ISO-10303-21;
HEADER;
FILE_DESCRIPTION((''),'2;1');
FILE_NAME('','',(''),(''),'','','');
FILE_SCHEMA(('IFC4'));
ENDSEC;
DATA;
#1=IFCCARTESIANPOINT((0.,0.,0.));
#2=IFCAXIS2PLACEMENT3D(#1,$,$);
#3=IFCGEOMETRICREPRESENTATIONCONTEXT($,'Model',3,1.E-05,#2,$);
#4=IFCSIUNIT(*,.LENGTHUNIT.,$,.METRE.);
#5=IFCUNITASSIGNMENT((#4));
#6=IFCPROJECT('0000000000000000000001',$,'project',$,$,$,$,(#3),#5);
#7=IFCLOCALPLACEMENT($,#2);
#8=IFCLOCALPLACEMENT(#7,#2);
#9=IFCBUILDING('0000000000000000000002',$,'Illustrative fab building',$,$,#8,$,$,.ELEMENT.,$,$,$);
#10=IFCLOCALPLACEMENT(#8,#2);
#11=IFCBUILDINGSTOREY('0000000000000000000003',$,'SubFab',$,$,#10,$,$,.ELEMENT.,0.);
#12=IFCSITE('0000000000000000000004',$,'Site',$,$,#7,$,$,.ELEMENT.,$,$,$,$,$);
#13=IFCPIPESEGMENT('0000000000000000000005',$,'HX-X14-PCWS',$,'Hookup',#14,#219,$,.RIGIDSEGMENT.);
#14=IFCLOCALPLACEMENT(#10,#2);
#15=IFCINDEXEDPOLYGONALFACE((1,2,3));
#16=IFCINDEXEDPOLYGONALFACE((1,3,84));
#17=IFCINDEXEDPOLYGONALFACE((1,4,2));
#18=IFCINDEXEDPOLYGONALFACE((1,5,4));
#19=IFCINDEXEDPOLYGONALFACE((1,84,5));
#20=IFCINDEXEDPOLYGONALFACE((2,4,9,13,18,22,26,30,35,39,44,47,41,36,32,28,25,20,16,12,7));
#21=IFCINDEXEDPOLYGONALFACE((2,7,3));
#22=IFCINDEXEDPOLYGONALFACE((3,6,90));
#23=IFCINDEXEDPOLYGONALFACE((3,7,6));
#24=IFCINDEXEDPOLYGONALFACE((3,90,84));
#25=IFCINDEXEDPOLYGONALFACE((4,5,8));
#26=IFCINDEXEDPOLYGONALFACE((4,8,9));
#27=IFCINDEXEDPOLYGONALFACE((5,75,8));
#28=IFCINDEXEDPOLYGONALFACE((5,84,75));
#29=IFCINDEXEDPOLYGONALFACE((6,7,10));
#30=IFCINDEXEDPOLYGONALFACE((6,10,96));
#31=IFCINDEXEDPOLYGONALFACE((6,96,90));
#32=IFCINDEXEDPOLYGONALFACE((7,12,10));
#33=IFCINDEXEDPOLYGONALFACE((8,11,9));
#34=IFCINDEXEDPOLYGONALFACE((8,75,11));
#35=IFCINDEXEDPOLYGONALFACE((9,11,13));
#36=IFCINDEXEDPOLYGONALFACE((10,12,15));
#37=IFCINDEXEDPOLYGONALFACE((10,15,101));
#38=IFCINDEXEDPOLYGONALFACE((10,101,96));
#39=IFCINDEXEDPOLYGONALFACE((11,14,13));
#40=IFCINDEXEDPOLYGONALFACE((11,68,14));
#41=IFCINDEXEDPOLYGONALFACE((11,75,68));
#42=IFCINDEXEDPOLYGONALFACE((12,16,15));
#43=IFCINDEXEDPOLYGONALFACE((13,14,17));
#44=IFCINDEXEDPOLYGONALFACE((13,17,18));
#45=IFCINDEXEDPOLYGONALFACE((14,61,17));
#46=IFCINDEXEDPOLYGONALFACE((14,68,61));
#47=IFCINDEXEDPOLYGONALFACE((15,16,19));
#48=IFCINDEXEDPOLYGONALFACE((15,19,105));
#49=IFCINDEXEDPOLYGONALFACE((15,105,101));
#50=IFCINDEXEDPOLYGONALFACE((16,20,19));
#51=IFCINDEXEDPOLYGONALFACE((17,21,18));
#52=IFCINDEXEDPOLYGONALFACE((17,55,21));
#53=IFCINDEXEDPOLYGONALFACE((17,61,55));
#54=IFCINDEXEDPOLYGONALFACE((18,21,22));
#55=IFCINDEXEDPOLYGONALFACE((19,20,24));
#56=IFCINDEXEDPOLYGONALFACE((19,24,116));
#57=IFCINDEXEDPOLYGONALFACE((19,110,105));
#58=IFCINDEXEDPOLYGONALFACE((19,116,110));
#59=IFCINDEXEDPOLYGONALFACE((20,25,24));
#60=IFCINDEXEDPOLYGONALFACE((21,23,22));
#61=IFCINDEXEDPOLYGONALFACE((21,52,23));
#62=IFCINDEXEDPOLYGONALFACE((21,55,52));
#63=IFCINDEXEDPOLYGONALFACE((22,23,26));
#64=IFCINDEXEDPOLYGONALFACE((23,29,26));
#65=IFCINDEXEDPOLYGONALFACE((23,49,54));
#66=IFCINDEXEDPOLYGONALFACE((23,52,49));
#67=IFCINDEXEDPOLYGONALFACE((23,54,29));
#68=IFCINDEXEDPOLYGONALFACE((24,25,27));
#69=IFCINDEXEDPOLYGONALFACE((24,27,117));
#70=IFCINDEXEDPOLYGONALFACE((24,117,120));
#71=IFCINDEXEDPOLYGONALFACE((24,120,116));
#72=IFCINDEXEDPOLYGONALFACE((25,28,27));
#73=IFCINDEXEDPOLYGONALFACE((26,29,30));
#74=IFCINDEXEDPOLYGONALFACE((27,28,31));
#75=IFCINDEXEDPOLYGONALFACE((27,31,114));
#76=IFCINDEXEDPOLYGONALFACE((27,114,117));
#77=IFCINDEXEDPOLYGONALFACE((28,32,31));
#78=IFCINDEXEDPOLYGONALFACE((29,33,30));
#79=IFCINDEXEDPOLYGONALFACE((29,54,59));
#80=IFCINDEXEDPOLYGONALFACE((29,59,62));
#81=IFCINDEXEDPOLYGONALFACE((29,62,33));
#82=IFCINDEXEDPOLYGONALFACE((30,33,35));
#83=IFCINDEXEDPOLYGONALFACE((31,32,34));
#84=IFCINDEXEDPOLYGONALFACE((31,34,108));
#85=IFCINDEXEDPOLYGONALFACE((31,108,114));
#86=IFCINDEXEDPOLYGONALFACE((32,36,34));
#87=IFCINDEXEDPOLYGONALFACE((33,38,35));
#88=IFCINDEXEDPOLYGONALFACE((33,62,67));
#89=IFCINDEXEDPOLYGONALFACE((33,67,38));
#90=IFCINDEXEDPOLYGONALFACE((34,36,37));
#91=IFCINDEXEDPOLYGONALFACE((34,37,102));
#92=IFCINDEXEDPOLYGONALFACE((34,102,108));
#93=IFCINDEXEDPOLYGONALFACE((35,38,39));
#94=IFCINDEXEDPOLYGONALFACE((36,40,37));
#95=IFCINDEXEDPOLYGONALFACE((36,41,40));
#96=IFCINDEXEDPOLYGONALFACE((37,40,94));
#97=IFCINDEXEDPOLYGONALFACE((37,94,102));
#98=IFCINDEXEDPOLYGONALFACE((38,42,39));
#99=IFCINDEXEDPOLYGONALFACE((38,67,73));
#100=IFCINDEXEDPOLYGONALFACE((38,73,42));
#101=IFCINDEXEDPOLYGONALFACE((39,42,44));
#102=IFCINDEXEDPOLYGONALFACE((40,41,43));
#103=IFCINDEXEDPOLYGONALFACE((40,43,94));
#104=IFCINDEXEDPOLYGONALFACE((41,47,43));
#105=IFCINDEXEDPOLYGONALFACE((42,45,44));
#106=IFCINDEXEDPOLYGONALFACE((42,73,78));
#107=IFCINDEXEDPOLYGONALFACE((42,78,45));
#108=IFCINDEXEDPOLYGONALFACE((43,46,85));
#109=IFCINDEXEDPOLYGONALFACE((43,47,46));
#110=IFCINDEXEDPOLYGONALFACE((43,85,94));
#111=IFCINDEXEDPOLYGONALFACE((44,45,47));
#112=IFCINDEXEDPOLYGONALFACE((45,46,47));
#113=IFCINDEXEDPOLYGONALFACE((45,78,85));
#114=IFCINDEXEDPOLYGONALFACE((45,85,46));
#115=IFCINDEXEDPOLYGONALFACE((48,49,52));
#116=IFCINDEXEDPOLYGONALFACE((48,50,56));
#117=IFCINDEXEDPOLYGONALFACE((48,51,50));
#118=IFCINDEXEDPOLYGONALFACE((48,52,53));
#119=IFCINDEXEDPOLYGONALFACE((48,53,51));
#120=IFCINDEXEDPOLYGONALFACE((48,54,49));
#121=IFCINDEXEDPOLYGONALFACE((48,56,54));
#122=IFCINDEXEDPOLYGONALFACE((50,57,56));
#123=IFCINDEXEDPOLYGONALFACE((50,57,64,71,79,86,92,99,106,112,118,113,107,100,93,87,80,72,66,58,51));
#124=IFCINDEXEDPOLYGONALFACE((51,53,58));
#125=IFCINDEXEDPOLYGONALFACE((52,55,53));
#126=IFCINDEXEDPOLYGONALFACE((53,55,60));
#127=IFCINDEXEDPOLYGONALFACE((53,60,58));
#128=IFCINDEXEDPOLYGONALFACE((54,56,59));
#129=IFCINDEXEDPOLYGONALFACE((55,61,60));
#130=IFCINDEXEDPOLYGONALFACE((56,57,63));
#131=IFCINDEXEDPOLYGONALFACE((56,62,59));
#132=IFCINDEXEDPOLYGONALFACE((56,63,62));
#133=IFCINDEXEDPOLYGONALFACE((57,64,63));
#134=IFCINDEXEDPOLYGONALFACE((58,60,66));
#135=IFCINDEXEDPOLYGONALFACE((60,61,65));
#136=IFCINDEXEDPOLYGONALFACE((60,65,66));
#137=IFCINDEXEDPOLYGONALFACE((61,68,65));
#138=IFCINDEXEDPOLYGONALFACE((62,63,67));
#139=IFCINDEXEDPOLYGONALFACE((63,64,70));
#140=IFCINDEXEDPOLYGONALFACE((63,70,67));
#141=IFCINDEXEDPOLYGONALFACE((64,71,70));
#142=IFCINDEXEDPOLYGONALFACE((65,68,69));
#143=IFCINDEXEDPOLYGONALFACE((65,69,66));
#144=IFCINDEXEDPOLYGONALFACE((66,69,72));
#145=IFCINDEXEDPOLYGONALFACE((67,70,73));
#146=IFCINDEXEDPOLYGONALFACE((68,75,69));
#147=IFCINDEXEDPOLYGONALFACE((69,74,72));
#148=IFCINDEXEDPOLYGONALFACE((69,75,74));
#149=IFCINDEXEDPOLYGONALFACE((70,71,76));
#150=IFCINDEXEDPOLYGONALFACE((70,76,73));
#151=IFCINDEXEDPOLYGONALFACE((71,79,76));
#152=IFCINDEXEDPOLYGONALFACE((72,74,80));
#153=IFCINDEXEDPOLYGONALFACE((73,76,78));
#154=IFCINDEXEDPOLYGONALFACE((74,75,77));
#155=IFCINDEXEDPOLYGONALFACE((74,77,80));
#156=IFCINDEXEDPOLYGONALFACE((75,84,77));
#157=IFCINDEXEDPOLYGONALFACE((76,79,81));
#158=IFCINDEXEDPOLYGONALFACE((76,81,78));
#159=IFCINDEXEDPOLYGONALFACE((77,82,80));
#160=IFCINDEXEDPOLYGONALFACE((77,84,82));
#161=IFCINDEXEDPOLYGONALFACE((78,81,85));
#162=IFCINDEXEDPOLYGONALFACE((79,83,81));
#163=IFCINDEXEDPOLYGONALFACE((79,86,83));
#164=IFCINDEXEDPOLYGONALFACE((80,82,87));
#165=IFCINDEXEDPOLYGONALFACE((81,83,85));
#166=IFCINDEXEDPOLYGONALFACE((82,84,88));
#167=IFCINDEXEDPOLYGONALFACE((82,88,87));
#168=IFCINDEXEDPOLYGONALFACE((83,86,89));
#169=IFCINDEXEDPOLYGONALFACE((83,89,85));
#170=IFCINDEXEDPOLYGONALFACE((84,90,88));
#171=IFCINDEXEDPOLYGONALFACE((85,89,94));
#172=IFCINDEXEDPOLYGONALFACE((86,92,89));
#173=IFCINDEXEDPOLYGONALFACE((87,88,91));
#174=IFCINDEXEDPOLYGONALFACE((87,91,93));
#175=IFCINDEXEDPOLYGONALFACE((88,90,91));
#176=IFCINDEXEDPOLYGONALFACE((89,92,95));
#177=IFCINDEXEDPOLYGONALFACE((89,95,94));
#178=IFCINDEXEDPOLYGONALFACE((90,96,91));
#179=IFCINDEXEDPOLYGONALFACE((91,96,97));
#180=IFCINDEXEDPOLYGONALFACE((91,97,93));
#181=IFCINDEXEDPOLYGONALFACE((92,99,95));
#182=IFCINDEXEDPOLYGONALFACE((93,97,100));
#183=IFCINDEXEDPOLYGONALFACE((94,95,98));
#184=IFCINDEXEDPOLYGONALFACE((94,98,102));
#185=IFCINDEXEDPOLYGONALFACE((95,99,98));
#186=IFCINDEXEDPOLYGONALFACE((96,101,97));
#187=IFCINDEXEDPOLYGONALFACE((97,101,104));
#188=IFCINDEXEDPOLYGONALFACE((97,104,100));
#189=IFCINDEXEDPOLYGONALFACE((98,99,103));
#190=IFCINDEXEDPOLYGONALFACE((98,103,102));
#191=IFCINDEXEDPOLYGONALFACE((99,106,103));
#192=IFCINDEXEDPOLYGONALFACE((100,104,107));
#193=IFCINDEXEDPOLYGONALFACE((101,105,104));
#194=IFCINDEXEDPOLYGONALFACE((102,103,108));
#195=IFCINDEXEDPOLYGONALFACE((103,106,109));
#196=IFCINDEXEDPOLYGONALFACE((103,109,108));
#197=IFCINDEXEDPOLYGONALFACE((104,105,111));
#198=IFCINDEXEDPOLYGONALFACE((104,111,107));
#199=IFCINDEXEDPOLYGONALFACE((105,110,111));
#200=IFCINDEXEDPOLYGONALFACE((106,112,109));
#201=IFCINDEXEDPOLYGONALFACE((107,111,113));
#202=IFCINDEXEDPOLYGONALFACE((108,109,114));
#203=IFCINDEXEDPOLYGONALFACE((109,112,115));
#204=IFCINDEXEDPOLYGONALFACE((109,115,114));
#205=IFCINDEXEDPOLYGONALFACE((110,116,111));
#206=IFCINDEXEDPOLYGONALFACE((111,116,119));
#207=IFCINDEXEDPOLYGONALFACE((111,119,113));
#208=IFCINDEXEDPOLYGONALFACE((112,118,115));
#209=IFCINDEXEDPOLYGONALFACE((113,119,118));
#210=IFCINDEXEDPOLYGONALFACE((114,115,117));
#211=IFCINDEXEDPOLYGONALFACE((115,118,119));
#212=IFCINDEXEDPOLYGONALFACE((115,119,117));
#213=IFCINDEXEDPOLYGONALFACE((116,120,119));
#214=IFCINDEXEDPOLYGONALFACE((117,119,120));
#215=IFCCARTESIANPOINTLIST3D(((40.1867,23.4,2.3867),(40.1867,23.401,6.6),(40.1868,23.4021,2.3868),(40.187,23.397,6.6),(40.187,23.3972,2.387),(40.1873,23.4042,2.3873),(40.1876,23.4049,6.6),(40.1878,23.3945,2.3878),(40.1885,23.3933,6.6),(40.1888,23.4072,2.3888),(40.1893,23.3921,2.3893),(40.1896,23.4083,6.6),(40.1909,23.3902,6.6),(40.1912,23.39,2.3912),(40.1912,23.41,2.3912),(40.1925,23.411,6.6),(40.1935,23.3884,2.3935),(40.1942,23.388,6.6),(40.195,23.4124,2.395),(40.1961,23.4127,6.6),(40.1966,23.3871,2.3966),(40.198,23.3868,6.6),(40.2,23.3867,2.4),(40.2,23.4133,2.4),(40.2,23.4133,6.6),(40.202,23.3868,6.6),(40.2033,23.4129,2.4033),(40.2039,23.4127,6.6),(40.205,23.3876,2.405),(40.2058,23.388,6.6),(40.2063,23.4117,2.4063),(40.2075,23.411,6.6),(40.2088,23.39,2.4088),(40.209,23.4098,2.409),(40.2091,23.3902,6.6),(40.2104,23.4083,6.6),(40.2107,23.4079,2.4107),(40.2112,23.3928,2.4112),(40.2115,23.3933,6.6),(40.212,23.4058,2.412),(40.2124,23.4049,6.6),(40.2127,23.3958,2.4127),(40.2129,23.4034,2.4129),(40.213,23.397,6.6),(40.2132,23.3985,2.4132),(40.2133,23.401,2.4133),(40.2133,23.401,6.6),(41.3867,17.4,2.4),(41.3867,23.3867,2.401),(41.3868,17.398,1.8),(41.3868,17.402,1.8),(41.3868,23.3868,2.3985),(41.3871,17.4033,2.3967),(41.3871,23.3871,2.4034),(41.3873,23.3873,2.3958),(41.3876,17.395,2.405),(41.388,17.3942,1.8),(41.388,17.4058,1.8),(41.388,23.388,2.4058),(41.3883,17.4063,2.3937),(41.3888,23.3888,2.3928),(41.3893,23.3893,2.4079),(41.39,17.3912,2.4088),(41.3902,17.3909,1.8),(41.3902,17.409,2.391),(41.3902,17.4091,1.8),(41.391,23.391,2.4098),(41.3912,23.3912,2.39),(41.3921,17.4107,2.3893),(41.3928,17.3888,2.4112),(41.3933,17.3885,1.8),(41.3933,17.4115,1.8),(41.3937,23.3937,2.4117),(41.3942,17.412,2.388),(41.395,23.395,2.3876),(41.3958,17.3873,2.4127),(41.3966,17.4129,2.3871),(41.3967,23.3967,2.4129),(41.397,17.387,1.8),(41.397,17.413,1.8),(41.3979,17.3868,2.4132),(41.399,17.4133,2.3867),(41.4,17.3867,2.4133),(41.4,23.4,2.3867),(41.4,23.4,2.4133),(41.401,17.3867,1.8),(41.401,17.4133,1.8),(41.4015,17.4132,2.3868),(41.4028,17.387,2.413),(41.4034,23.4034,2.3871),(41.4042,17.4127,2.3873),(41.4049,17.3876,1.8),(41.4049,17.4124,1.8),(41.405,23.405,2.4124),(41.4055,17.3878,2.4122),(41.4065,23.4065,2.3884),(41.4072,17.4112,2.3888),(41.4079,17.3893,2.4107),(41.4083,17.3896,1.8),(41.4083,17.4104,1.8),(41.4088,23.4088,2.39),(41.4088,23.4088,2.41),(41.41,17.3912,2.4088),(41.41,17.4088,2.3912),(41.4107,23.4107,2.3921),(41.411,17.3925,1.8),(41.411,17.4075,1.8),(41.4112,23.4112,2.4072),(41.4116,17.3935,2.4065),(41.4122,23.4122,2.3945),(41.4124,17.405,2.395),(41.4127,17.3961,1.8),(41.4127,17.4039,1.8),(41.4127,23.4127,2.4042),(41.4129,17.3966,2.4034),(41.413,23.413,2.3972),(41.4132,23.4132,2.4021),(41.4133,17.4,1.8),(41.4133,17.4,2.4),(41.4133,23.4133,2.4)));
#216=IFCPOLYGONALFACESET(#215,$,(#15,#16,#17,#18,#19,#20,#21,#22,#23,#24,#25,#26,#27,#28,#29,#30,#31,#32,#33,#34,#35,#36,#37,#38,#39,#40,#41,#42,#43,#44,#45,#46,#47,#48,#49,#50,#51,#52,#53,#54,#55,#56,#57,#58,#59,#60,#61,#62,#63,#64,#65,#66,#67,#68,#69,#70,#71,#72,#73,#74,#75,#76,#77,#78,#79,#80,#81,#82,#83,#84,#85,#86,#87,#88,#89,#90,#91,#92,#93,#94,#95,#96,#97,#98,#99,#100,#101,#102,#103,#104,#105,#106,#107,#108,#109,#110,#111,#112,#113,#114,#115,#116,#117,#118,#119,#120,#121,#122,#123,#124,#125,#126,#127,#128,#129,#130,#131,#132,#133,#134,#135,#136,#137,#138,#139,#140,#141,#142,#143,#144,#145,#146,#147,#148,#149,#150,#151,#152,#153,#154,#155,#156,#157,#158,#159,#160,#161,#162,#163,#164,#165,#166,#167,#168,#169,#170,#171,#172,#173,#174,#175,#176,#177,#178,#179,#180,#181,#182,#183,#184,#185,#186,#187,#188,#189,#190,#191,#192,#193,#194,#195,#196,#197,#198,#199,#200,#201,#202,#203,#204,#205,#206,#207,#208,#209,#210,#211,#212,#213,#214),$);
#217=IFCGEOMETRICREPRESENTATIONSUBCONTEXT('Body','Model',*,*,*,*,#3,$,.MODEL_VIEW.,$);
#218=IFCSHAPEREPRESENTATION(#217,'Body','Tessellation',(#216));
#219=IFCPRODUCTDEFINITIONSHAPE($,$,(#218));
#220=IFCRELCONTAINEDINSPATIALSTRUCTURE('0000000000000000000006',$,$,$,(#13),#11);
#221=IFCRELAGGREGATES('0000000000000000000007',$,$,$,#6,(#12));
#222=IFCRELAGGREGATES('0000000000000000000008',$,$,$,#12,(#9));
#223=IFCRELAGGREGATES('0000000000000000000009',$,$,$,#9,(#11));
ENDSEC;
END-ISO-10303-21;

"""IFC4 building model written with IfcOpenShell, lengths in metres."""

from ifc_helpers import new_model, entity, si_unit, origin, place, context, subcontext, project, spatial, element, save


model = new_model("IFC4")

# Units and contexts
model_context = context("Model", 3, precision=1e-05, world=origin())
body_context = subcontext(model_context, "Body", "Model", "MODEL_VIEW")
ifc_project = project(units=[si_unit("LENGTHUNIT", "METRE")], contexts=[model_context])

# Site, building, storey
site_placement = place(None, origin())
site = spatial("IfcSite", under=ifc_project, at=site_placement, Name="Site", CompositionType="ELEMENT")
building_placement = place(site_placement, origin())
building = spatial("IfcBuilding", under=site, at=building_placement, Name="Illustrative fab building", CompositionType="ELEMENT")
storey_placement = place(building_placement, origin())
storey = spatial("IfcBuildingStorey", under=building, at=storey_placement, Name="SubFab", CompositionType="ELEMENT", Elevation=0.0)

# Pipe segment
pipe_segment_1_placement = place(storey_placement, origin())
element("IfcPipeSegment", 1, at=pipe_segment_1_placement, inside=storey, Name="HX-X14-PCWS", ObjectType="Hookup", PredefinedType="RIGIDSEGMENT", context=body_context, shape_type="AdvancedSweptSolid", body=[
    entity("IfcSweptDiskSolid", entity("IfcPolyline", [entity("IfcCartesianPoint", [41.4, 17.4, 1.8]), entity("IfcCartesianPoint", [41.4, 17.4, 2.4]), entity("IfcCartesianPoint", [41.4, 23.4, 2.4]), entity("IfcCartesianPoint", [40.2, 23.4, 2.4]), entity("IfcCartesianPoint", [40.2, 23.4, 6.6])]), 0.0133),
])

save(model, "model.ifc")
